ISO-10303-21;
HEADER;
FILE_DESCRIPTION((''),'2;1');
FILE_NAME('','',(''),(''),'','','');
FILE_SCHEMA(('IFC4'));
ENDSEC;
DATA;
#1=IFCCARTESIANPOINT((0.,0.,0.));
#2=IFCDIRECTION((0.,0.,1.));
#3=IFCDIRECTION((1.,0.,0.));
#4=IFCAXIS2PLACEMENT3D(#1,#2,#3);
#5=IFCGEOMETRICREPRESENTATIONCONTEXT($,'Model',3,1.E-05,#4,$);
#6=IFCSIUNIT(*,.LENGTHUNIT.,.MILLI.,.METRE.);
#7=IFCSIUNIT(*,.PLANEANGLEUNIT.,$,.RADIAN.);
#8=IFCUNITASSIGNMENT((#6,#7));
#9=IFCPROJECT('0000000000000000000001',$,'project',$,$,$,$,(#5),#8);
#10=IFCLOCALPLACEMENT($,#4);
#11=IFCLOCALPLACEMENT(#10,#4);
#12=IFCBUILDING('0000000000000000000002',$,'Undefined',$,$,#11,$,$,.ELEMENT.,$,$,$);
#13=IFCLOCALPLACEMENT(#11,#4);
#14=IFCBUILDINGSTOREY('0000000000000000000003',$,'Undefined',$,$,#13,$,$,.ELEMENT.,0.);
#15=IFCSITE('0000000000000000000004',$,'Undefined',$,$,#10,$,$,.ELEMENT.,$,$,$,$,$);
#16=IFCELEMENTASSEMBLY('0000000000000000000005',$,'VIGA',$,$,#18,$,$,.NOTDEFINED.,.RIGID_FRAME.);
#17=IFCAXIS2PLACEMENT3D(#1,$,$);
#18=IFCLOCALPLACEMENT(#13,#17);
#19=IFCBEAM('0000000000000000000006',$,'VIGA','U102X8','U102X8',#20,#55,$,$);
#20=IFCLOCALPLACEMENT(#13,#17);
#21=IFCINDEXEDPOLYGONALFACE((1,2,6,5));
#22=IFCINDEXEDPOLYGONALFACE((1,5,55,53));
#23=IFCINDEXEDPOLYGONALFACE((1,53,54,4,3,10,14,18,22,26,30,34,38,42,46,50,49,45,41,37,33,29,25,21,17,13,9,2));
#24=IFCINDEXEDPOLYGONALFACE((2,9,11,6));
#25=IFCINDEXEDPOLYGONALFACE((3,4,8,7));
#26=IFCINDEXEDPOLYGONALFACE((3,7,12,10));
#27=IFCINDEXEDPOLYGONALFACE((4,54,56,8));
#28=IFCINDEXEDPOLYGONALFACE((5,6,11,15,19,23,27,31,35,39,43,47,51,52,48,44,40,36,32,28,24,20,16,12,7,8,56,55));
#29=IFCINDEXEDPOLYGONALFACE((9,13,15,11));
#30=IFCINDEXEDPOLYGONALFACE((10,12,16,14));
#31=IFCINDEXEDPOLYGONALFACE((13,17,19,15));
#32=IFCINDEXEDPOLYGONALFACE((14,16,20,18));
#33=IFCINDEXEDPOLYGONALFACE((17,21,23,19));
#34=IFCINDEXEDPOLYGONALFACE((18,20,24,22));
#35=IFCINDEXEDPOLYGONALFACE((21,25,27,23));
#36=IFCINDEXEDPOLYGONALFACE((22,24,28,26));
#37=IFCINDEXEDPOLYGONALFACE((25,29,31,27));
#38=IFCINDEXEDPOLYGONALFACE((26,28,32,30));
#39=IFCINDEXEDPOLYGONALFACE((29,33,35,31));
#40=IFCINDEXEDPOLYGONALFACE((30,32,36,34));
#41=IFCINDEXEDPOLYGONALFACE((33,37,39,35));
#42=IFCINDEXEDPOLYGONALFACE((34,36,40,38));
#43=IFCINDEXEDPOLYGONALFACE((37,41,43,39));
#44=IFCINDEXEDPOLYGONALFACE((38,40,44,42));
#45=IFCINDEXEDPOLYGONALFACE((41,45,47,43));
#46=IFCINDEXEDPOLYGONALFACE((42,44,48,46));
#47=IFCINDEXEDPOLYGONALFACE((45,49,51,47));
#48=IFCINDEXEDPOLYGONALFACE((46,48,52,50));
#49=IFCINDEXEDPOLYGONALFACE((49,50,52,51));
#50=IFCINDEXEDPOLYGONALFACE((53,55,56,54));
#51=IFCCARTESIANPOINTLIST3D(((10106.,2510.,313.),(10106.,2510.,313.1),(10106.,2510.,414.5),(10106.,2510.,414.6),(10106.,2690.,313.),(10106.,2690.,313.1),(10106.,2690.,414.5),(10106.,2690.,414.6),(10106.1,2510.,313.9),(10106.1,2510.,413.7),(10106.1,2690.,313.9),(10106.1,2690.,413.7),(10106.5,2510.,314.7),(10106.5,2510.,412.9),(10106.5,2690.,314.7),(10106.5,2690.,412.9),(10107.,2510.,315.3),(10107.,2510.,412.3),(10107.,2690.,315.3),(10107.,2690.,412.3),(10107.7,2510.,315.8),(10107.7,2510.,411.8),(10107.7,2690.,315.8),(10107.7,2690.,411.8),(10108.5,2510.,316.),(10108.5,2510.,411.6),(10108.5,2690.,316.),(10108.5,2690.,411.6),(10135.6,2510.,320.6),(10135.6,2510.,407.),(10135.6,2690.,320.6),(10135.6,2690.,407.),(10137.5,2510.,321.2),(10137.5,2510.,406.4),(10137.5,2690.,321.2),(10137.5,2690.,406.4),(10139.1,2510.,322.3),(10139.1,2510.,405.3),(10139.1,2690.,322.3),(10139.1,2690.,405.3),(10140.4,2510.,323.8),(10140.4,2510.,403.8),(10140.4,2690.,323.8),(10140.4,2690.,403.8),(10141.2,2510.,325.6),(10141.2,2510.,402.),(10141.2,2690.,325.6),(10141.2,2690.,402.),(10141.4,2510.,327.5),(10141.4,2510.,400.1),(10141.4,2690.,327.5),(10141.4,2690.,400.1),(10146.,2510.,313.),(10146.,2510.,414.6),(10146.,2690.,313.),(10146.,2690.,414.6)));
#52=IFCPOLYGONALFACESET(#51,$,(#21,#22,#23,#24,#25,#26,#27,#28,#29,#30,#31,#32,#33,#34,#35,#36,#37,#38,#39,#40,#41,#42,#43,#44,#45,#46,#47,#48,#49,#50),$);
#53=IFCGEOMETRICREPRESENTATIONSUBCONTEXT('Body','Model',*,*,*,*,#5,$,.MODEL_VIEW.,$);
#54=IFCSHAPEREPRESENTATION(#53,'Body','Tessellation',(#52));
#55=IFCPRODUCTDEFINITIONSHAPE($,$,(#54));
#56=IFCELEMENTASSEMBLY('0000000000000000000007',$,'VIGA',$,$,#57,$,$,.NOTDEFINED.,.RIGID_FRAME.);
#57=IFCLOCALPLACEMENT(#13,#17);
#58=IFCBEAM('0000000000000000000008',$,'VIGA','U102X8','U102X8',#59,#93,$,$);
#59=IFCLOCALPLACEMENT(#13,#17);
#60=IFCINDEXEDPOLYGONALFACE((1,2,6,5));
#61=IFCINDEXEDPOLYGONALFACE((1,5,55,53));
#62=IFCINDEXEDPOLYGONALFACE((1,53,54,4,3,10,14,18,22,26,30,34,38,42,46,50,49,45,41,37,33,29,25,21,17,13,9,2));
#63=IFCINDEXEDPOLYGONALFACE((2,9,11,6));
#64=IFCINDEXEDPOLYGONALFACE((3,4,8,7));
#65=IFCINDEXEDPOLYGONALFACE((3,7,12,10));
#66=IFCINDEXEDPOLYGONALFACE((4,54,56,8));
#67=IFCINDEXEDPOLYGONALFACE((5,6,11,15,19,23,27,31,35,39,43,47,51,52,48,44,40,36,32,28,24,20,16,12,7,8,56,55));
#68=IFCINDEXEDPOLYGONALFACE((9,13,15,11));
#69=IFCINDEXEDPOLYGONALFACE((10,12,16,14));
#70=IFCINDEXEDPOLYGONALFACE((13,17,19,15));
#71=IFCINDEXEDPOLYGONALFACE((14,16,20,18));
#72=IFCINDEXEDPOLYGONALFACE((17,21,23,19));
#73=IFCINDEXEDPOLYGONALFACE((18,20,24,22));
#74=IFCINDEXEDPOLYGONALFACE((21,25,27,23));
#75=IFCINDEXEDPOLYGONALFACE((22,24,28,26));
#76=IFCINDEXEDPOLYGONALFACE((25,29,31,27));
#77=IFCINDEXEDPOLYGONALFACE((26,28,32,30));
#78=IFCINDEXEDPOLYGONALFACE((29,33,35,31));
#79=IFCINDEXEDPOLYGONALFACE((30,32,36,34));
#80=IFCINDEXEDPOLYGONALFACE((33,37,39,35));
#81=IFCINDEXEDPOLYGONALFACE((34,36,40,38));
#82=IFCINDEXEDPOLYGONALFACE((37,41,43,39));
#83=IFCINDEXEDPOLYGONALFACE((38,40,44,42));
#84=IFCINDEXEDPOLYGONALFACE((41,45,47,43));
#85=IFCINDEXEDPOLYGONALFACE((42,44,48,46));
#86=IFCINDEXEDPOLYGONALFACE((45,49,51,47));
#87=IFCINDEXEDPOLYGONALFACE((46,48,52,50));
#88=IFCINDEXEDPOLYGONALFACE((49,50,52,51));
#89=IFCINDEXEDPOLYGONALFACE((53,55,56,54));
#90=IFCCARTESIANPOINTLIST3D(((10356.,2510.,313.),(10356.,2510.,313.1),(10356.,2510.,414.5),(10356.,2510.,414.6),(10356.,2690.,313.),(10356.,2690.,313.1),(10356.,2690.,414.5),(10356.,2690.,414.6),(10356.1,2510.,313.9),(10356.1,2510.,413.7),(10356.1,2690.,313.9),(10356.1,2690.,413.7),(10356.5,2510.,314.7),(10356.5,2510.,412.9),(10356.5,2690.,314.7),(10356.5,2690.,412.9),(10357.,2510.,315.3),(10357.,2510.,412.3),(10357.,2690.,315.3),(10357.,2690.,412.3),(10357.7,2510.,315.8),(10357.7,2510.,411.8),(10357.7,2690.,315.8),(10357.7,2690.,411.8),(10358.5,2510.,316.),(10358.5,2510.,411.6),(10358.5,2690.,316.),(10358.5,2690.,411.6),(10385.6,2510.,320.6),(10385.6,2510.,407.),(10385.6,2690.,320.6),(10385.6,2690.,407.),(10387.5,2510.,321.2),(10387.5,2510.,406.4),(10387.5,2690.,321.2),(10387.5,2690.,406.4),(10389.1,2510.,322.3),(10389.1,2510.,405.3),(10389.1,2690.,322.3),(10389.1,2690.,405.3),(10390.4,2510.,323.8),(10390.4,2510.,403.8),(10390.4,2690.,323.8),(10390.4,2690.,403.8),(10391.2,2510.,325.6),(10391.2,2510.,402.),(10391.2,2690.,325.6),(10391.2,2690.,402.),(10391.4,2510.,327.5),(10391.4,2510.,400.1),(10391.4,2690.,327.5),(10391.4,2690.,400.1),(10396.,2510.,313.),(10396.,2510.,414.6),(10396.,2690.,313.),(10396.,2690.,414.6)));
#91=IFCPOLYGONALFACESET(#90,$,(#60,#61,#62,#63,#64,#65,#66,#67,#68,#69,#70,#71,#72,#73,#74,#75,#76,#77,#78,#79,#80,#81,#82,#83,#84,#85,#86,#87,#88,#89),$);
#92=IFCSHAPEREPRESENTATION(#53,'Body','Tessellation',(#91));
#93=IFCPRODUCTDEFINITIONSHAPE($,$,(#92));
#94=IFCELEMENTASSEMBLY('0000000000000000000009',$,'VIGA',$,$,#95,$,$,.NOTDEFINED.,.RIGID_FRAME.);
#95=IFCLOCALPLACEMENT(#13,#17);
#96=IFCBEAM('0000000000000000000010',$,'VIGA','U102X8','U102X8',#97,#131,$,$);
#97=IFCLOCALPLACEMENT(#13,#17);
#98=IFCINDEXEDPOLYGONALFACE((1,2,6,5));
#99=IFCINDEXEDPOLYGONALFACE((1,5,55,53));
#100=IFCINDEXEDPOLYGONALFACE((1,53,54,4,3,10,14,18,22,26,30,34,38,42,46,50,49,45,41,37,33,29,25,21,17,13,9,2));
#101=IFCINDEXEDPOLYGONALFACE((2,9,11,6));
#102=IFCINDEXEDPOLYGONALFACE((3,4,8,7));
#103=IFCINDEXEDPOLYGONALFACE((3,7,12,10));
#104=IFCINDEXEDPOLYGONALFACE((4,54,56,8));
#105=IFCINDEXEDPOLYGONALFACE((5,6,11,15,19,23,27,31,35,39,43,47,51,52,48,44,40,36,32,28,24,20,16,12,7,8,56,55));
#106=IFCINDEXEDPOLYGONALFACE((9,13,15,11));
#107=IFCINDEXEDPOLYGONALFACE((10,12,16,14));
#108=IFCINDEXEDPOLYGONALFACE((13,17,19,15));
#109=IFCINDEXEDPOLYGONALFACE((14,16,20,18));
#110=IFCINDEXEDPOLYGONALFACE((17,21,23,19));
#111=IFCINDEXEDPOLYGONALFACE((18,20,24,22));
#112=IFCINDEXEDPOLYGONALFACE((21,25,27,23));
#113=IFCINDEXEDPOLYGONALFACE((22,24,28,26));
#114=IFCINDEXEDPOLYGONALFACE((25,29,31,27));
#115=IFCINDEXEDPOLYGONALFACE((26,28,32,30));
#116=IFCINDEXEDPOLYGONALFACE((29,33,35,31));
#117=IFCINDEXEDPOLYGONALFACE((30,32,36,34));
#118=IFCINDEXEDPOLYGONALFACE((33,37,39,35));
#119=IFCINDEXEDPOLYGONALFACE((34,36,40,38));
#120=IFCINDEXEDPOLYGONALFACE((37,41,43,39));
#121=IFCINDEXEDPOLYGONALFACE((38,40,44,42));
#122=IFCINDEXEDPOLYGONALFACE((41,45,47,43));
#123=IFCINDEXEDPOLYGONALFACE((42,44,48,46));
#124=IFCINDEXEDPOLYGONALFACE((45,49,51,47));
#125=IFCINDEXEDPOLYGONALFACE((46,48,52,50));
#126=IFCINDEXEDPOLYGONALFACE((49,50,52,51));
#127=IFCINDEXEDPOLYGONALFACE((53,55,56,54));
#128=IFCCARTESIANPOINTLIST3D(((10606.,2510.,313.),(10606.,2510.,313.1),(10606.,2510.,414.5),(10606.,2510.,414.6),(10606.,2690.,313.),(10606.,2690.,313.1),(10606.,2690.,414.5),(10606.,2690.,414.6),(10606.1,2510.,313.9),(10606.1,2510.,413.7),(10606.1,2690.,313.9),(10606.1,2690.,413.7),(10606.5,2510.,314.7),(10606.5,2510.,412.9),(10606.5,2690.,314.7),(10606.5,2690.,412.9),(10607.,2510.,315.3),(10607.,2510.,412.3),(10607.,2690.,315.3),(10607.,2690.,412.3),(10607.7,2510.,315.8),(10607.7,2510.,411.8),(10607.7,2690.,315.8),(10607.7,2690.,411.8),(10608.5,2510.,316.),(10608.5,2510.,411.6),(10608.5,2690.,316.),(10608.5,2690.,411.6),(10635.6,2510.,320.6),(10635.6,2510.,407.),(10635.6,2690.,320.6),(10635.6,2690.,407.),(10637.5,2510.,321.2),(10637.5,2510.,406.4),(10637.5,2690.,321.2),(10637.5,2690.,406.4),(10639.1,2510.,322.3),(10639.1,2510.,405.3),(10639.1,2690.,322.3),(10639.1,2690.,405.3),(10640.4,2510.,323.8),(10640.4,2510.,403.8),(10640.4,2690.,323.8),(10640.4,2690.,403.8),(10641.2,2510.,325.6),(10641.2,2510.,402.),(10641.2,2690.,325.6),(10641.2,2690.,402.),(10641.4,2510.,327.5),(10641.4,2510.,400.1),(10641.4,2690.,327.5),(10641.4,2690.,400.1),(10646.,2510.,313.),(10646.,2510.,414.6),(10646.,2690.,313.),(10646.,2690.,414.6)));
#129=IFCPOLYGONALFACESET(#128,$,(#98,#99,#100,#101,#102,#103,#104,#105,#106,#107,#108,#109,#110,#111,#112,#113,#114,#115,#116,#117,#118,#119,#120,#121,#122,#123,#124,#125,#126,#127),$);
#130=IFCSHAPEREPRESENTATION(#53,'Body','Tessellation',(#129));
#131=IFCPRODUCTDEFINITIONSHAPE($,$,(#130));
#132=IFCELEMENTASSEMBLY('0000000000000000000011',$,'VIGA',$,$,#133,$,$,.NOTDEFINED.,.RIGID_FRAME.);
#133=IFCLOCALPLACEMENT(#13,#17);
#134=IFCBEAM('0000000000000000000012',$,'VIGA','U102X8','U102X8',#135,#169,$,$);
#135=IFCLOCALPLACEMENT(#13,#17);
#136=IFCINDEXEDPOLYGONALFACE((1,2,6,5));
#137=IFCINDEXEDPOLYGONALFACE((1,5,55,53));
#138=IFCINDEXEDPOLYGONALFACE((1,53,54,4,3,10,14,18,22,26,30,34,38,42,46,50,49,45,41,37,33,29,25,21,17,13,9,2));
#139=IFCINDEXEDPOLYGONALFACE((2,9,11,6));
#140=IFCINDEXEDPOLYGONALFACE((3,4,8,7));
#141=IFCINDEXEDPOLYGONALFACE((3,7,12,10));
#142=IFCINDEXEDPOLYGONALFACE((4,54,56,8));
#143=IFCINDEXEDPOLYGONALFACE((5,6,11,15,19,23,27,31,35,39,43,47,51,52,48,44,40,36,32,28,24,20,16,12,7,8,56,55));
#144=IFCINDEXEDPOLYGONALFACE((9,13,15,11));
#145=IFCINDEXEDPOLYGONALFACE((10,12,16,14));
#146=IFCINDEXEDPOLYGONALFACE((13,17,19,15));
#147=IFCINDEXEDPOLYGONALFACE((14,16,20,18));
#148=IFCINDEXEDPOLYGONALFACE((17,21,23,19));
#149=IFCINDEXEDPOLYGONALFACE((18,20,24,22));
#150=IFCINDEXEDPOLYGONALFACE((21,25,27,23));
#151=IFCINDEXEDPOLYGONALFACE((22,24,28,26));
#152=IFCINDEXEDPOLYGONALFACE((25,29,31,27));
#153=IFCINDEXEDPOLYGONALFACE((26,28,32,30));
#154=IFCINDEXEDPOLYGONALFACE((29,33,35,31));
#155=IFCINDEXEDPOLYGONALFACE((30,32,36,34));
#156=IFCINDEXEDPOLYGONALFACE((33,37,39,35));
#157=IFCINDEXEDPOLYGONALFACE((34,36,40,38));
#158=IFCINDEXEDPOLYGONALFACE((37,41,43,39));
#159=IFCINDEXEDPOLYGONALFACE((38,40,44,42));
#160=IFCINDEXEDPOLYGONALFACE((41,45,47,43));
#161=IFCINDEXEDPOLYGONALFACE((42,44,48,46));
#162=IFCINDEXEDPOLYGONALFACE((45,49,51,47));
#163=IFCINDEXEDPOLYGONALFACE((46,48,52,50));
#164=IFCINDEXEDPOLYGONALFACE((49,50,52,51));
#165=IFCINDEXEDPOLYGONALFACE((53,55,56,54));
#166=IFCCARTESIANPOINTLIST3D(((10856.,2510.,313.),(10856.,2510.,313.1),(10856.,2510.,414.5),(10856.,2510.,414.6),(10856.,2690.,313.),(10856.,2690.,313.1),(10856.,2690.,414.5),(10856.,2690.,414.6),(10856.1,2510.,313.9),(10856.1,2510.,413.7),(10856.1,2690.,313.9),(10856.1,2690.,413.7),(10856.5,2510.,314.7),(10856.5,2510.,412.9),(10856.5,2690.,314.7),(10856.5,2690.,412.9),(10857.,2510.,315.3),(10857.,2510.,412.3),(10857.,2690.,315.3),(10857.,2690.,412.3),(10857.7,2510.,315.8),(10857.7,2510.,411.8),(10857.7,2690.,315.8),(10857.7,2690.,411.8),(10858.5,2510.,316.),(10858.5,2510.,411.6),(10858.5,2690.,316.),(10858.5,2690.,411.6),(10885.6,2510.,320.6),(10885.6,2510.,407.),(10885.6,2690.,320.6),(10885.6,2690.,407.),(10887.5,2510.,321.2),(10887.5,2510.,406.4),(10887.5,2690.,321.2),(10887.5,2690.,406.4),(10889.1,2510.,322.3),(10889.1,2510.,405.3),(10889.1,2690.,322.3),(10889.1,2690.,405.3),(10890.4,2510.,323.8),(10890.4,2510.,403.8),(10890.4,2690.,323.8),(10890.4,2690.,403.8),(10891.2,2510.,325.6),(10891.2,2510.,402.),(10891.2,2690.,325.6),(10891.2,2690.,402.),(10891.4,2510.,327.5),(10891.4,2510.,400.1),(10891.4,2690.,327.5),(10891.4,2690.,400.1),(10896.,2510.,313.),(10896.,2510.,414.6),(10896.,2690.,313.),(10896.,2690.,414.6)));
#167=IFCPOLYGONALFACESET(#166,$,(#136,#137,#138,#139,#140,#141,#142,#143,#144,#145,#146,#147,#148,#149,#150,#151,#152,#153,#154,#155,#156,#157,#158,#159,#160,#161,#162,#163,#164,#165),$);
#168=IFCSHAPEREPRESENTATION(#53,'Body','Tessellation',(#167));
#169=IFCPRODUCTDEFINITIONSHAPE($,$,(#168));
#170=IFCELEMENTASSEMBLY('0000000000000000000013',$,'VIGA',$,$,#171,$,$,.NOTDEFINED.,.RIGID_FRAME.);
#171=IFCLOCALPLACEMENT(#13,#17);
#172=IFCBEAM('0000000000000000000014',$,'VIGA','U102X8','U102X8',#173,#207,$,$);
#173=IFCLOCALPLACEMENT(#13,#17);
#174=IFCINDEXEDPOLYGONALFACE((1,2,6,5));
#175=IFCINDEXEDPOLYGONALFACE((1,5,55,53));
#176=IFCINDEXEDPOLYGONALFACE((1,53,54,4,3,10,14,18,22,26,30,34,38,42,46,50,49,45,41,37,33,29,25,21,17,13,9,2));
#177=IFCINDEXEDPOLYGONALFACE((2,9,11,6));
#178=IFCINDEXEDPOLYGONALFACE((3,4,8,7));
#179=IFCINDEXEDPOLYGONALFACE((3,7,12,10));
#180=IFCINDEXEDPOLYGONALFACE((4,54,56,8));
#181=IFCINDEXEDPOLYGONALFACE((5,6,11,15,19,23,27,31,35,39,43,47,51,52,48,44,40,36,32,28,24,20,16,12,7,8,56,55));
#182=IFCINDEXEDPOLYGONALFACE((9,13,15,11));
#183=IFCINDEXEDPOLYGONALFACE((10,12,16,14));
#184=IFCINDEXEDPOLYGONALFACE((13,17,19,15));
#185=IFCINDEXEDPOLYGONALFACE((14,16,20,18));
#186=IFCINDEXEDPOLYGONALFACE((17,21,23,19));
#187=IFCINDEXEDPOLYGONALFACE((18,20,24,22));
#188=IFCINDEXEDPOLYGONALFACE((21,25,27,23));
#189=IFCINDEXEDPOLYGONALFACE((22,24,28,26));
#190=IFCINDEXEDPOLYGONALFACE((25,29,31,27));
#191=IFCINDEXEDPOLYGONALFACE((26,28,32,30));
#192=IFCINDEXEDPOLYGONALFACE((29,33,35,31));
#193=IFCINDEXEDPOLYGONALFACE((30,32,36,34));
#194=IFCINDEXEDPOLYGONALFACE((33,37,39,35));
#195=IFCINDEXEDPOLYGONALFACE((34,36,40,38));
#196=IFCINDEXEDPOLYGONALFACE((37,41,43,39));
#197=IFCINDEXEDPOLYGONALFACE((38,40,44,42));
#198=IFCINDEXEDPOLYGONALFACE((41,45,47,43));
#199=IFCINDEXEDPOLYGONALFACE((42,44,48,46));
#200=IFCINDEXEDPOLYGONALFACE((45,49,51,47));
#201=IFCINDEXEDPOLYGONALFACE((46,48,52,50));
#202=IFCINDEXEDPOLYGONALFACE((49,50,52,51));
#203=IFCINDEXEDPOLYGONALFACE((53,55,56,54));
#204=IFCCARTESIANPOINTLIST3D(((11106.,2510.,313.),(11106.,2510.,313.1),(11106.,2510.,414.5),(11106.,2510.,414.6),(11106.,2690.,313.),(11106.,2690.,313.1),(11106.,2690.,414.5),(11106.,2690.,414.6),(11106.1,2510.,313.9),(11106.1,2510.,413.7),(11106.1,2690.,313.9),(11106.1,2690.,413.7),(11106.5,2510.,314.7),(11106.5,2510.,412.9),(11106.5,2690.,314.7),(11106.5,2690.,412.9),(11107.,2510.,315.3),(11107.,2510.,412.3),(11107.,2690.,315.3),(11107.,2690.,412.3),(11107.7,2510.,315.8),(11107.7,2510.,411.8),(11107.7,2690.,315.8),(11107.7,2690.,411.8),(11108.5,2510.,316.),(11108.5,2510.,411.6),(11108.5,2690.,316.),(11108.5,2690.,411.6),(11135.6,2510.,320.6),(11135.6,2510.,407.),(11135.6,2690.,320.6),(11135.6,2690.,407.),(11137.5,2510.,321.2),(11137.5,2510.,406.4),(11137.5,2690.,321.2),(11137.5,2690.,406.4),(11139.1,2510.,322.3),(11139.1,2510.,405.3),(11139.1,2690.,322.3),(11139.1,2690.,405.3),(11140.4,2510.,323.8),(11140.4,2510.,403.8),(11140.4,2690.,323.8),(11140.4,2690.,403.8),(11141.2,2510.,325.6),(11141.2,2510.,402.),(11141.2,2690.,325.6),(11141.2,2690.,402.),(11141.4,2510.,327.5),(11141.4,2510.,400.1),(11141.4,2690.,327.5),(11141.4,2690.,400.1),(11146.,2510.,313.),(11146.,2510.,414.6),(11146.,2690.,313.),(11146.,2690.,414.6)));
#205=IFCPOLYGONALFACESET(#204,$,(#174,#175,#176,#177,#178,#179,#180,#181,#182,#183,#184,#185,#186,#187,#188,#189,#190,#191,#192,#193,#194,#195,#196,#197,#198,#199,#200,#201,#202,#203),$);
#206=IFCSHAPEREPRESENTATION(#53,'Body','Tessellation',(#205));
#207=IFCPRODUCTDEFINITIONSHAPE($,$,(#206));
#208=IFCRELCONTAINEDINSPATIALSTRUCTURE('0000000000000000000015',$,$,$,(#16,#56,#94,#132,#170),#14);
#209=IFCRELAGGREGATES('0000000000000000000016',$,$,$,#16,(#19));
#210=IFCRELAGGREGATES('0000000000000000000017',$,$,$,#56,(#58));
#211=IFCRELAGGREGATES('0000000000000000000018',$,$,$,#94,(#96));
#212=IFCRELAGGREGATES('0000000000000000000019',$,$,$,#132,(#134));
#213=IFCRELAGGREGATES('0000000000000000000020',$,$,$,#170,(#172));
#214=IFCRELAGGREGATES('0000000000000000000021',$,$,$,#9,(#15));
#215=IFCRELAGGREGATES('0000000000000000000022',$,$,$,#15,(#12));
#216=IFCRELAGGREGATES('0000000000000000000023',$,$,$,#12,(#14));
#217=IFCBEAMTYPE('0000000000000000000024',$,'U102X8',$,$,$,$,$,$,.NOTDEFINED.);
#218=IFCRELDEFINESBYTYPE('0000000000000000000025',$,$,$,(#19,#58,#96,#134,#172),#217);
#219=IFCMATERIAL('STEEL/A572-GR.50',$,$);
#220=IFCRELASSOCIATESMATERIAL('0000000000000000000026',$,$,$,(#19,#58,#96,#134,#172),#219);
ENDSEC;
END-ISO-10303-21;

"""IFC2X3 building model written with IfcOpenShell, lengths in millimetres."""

from ifc_helpers import new_model, si_unit, frame, origin_with_axes, origin_2d_with_axis, place, context, subcontext, project, spatial, u_section, extrude, material, type_object, element, aggregate, save


model = new_model("IFC2X3")

# Units and contexts
model_context = context("Model", 3, precision=1e-05, world=origin_with_axes())
body_context = subcontext(model_context, "Body", "Model", "MODEL_VIEW")
ifc_project = project(units=[si_unit("LENGTHUNIT", "METRE", prefix="MILLI"), si_unit("PLANEANGLEUNIT", "RADIAN")], contexts=[model_context])

# Site, building, storey
site_placement = place(None, origin_with_axes())
site = spatial("IfcSite", under=ifc_project, at=site_placement, Name="Undefined", CompositionType="ELEMENT")
building_placement = place(site_placement, origin_with_axes())
building = spatial("IfcBuilding", under=site, at=building_placement, Name="Undefined", CompositionType="ELEMENT")
storey_placement = place(building_placement, origin_with_axes())
storey = spatial("IfcBuildingStorey", under=building, at=storey_placement, Name="Undefined", CompositionType="ELEMENT", Elevation=0.0)

# Element assemblies, beams
ifc_material_1 = material(Name="STEEL/A572-GR.50")
beam_type_1 = type_object("IfcBeamType", Name="U102X8", PredefinedType="NOTDEFINED")
assembly_1_placement = place(storey_placement, origin_with_axes())
assembly_1 = element("IfcElementAssembly", 1, at=assembly_1_placement, inside=storey, Name="VIGA", AssemblyPlace="NOTDEFINED", PredefinedType="RIGID_FRAME")
beam_1_placement = place(assembly_1_placement, frame((10126.0, 2690.0, 363.8), z_axis=(0.0, 0.0, 1.0), x_axis=(0.0, -1.0, 0.0)))
beam_1 = element("IfcBeam", 2, at=beam_1_placement, type_object=beam_type_1, material=ifc_material_1, Name="VIGA", Description="U102X8", ObjectType="U102X8", context=body_context, shape_type="SweptSolid", body=[
    extrude(u_section(Depth=101.6, FlangeWidth=40.0, WebThickness=4.6, FlangeThickness=6.0, FilletRadius=7.0, EdgeRadius=3.0, FlangeSlope=0.16839, at=origin_2d_with_axis()), frame((180.0, 0.0, 0.0), z_axis=(-1.0, 0.0, 0.0), x_axis=(0.0, -1.0, 0.0)), (0.0, 0.0, 1.0), 180.0),
])
aggregate(assembly_1, [beam_1])
assembly_2_placement = place(storey_placement, origin_with_axes())
assembly_2 = element("IfcElementAssembly", 3, at=assembly_2_placement, inside=storey, Name="VIGA", AssemblyPlace="NOTDEFINED", PredefinedType="RIGID_FRAME")
beam_2_placement = place(assembly_2_placement, frame((10376.0, 2690.0, 363.8), z_axis=(0.0, 0.0, 1.0), x_axis=(0.0, -1.0, 0.0)))
beam_2 = element("IfcBeam", 4, at=beam_2_placement, type_object=beam_type_1, material=ifc_material_1, Name="VIGA", Description="U102X8", ObjectType="U102X8", context=body_context, shape_type="SweptSolid", body=[
    extrude(u_section(Depth=101.6, FlangeWidth=40.0, WebThickness=4.6, FlangeThickness=6.0, FilletRadius=7.0, EdgeRadius=3.0, FlangeSlope=0.16839, at=origin_2d_with_axis()), frame((180.0, 0.0, 0.0), z_axis=(-1.0, 0.0, 0.0), x_axis=(0.0, -1.0, 0.0)), (0.0, 0.0, 1.0), 180.0),
])
aggregate(assembly_2, [beam_2])
assembly_3_placement = place(storey_placement, origin_with_axes())
assembly_3 = element("IfcElementAssembly", 5, at=assembly_3_placement, inside=storey, Name="VIGA", AssemblyPlace="NOTDEFINED", PredefinedType="RIGID_FRAME")
beam_3_placement = place(assembly_3_placement, frame((10626.0, 2690.0, 363.8), z_axis=(0.0, 0.0, 1.0), x_axis=(0.0, -1.0, 0.0)))
beam_3 = element("IfcBeam", 6, at=beam_3_placement, type_object=beam_type_1, material=ifc_material_1, Name="VIGA", Description="U102X8", ObjectType="U102X8", context=body_context, shape_type="SweptSolid", body=[
    extrude(u_section(Depth=101.6, FlangeWidth=40.0, WebThickness=4.6, FlangeThickness=6.0, FilletRadius=7.0, EdgeRadius=3.0, FlangeSlope=0.16839, at=origin_2d_with_axis()), frame((180.0, 0.0, 0.0), z_axis=(-1.0, 0.0, 0.0), x_axis=(0.0, -1.0, 0.0)), (0.0, 0.0, 1.0), 180.0),
])
aggregate(assembly_3, [beam_3])
assembly_4_placement = place(storey_placement, origin_with_axes())
assembly_4 = element("IfcElementAssembly", 7, at=assembly_4_placement, inside=storey, Name="VIGA", AssemblyPlace="NOTDEFINED", PredefinedType="RIGID_FRAME")
beam_4_placement = place(assembly_4_placement, frame((10876.0, 2690.0, 363.8), z_axis=(0.0, 0.0, 1.0), x_axis=(0.0, -1.0, 0.0)))
beam_4 = element("IfcBeam", 8, at=beam_4_placement, type_object=beam_type_1, material=ifc_material_1, Name="VIGA", Description="U102X8", ObjectType="U102X8", context=body_context, shape_type="SweptSolid", body=[
    extrude(u_section(Depth=101.6, FlangeWidth=40.0, WebThickness=4.6, FlangeThickness=6.0, FilletRadius=7.0, EdgeRadius=3.0, FlangeSlope=0.16839, at=origin_2d_with_axis()), frame((180.0, 0.0, 0.0), z_axis=(-1.0, 0.0, 0.0), x_axis=(0.0, -1.0, 0.0)), (0.0, 0.0, 1.0), 180.0),
])
aggregate(assembly_4, [beam_4])
assembly_5_placement = place(storey_placement, origin_with_axes())
assembly_5 = element("IfcElementAssembly", 9, at=assembly_5_placement, inside=storey, Name="VIGA", AssemblyPlace="NOTDEFINED", PredefinedType="RIGID_FRAME")
beam_5_placement = place(assembly_5_placement, frame((11126.0, 2690.0, 363.8), z_axis=(0.0, 0.0, 1.0), x_axis=(0.0, -1.0, 0.0)))
beam_5 = element("IfcBeam", 10, at=beam_5_placement, type_object=beam_type_1, material=ifc_material_1, Name="VIGA", Description="U102X8", ObjectType="U102X8", context=body_context, shape_type="SweptSolid", body=[
    extrude(u_section(Depth=101.6, FlangeWidth=40.0, WebThickness=4.6, FlangeThickness=6.0, FilletRadius=7.0, EdgeRadius=3.0, FlangeSlope=0.16839, at=origin_2d_with_axis()), frame((180.0, 0.0, 0.0), z_axis=(-1.0, 0.0, 0.0), x_axis=(0.0, -1.0, 0.0)), (0.0, 0.0, 1.0), 180.0),
])
aggregate(assembly_5, [beam_5])

save(model, "model.ifc")
